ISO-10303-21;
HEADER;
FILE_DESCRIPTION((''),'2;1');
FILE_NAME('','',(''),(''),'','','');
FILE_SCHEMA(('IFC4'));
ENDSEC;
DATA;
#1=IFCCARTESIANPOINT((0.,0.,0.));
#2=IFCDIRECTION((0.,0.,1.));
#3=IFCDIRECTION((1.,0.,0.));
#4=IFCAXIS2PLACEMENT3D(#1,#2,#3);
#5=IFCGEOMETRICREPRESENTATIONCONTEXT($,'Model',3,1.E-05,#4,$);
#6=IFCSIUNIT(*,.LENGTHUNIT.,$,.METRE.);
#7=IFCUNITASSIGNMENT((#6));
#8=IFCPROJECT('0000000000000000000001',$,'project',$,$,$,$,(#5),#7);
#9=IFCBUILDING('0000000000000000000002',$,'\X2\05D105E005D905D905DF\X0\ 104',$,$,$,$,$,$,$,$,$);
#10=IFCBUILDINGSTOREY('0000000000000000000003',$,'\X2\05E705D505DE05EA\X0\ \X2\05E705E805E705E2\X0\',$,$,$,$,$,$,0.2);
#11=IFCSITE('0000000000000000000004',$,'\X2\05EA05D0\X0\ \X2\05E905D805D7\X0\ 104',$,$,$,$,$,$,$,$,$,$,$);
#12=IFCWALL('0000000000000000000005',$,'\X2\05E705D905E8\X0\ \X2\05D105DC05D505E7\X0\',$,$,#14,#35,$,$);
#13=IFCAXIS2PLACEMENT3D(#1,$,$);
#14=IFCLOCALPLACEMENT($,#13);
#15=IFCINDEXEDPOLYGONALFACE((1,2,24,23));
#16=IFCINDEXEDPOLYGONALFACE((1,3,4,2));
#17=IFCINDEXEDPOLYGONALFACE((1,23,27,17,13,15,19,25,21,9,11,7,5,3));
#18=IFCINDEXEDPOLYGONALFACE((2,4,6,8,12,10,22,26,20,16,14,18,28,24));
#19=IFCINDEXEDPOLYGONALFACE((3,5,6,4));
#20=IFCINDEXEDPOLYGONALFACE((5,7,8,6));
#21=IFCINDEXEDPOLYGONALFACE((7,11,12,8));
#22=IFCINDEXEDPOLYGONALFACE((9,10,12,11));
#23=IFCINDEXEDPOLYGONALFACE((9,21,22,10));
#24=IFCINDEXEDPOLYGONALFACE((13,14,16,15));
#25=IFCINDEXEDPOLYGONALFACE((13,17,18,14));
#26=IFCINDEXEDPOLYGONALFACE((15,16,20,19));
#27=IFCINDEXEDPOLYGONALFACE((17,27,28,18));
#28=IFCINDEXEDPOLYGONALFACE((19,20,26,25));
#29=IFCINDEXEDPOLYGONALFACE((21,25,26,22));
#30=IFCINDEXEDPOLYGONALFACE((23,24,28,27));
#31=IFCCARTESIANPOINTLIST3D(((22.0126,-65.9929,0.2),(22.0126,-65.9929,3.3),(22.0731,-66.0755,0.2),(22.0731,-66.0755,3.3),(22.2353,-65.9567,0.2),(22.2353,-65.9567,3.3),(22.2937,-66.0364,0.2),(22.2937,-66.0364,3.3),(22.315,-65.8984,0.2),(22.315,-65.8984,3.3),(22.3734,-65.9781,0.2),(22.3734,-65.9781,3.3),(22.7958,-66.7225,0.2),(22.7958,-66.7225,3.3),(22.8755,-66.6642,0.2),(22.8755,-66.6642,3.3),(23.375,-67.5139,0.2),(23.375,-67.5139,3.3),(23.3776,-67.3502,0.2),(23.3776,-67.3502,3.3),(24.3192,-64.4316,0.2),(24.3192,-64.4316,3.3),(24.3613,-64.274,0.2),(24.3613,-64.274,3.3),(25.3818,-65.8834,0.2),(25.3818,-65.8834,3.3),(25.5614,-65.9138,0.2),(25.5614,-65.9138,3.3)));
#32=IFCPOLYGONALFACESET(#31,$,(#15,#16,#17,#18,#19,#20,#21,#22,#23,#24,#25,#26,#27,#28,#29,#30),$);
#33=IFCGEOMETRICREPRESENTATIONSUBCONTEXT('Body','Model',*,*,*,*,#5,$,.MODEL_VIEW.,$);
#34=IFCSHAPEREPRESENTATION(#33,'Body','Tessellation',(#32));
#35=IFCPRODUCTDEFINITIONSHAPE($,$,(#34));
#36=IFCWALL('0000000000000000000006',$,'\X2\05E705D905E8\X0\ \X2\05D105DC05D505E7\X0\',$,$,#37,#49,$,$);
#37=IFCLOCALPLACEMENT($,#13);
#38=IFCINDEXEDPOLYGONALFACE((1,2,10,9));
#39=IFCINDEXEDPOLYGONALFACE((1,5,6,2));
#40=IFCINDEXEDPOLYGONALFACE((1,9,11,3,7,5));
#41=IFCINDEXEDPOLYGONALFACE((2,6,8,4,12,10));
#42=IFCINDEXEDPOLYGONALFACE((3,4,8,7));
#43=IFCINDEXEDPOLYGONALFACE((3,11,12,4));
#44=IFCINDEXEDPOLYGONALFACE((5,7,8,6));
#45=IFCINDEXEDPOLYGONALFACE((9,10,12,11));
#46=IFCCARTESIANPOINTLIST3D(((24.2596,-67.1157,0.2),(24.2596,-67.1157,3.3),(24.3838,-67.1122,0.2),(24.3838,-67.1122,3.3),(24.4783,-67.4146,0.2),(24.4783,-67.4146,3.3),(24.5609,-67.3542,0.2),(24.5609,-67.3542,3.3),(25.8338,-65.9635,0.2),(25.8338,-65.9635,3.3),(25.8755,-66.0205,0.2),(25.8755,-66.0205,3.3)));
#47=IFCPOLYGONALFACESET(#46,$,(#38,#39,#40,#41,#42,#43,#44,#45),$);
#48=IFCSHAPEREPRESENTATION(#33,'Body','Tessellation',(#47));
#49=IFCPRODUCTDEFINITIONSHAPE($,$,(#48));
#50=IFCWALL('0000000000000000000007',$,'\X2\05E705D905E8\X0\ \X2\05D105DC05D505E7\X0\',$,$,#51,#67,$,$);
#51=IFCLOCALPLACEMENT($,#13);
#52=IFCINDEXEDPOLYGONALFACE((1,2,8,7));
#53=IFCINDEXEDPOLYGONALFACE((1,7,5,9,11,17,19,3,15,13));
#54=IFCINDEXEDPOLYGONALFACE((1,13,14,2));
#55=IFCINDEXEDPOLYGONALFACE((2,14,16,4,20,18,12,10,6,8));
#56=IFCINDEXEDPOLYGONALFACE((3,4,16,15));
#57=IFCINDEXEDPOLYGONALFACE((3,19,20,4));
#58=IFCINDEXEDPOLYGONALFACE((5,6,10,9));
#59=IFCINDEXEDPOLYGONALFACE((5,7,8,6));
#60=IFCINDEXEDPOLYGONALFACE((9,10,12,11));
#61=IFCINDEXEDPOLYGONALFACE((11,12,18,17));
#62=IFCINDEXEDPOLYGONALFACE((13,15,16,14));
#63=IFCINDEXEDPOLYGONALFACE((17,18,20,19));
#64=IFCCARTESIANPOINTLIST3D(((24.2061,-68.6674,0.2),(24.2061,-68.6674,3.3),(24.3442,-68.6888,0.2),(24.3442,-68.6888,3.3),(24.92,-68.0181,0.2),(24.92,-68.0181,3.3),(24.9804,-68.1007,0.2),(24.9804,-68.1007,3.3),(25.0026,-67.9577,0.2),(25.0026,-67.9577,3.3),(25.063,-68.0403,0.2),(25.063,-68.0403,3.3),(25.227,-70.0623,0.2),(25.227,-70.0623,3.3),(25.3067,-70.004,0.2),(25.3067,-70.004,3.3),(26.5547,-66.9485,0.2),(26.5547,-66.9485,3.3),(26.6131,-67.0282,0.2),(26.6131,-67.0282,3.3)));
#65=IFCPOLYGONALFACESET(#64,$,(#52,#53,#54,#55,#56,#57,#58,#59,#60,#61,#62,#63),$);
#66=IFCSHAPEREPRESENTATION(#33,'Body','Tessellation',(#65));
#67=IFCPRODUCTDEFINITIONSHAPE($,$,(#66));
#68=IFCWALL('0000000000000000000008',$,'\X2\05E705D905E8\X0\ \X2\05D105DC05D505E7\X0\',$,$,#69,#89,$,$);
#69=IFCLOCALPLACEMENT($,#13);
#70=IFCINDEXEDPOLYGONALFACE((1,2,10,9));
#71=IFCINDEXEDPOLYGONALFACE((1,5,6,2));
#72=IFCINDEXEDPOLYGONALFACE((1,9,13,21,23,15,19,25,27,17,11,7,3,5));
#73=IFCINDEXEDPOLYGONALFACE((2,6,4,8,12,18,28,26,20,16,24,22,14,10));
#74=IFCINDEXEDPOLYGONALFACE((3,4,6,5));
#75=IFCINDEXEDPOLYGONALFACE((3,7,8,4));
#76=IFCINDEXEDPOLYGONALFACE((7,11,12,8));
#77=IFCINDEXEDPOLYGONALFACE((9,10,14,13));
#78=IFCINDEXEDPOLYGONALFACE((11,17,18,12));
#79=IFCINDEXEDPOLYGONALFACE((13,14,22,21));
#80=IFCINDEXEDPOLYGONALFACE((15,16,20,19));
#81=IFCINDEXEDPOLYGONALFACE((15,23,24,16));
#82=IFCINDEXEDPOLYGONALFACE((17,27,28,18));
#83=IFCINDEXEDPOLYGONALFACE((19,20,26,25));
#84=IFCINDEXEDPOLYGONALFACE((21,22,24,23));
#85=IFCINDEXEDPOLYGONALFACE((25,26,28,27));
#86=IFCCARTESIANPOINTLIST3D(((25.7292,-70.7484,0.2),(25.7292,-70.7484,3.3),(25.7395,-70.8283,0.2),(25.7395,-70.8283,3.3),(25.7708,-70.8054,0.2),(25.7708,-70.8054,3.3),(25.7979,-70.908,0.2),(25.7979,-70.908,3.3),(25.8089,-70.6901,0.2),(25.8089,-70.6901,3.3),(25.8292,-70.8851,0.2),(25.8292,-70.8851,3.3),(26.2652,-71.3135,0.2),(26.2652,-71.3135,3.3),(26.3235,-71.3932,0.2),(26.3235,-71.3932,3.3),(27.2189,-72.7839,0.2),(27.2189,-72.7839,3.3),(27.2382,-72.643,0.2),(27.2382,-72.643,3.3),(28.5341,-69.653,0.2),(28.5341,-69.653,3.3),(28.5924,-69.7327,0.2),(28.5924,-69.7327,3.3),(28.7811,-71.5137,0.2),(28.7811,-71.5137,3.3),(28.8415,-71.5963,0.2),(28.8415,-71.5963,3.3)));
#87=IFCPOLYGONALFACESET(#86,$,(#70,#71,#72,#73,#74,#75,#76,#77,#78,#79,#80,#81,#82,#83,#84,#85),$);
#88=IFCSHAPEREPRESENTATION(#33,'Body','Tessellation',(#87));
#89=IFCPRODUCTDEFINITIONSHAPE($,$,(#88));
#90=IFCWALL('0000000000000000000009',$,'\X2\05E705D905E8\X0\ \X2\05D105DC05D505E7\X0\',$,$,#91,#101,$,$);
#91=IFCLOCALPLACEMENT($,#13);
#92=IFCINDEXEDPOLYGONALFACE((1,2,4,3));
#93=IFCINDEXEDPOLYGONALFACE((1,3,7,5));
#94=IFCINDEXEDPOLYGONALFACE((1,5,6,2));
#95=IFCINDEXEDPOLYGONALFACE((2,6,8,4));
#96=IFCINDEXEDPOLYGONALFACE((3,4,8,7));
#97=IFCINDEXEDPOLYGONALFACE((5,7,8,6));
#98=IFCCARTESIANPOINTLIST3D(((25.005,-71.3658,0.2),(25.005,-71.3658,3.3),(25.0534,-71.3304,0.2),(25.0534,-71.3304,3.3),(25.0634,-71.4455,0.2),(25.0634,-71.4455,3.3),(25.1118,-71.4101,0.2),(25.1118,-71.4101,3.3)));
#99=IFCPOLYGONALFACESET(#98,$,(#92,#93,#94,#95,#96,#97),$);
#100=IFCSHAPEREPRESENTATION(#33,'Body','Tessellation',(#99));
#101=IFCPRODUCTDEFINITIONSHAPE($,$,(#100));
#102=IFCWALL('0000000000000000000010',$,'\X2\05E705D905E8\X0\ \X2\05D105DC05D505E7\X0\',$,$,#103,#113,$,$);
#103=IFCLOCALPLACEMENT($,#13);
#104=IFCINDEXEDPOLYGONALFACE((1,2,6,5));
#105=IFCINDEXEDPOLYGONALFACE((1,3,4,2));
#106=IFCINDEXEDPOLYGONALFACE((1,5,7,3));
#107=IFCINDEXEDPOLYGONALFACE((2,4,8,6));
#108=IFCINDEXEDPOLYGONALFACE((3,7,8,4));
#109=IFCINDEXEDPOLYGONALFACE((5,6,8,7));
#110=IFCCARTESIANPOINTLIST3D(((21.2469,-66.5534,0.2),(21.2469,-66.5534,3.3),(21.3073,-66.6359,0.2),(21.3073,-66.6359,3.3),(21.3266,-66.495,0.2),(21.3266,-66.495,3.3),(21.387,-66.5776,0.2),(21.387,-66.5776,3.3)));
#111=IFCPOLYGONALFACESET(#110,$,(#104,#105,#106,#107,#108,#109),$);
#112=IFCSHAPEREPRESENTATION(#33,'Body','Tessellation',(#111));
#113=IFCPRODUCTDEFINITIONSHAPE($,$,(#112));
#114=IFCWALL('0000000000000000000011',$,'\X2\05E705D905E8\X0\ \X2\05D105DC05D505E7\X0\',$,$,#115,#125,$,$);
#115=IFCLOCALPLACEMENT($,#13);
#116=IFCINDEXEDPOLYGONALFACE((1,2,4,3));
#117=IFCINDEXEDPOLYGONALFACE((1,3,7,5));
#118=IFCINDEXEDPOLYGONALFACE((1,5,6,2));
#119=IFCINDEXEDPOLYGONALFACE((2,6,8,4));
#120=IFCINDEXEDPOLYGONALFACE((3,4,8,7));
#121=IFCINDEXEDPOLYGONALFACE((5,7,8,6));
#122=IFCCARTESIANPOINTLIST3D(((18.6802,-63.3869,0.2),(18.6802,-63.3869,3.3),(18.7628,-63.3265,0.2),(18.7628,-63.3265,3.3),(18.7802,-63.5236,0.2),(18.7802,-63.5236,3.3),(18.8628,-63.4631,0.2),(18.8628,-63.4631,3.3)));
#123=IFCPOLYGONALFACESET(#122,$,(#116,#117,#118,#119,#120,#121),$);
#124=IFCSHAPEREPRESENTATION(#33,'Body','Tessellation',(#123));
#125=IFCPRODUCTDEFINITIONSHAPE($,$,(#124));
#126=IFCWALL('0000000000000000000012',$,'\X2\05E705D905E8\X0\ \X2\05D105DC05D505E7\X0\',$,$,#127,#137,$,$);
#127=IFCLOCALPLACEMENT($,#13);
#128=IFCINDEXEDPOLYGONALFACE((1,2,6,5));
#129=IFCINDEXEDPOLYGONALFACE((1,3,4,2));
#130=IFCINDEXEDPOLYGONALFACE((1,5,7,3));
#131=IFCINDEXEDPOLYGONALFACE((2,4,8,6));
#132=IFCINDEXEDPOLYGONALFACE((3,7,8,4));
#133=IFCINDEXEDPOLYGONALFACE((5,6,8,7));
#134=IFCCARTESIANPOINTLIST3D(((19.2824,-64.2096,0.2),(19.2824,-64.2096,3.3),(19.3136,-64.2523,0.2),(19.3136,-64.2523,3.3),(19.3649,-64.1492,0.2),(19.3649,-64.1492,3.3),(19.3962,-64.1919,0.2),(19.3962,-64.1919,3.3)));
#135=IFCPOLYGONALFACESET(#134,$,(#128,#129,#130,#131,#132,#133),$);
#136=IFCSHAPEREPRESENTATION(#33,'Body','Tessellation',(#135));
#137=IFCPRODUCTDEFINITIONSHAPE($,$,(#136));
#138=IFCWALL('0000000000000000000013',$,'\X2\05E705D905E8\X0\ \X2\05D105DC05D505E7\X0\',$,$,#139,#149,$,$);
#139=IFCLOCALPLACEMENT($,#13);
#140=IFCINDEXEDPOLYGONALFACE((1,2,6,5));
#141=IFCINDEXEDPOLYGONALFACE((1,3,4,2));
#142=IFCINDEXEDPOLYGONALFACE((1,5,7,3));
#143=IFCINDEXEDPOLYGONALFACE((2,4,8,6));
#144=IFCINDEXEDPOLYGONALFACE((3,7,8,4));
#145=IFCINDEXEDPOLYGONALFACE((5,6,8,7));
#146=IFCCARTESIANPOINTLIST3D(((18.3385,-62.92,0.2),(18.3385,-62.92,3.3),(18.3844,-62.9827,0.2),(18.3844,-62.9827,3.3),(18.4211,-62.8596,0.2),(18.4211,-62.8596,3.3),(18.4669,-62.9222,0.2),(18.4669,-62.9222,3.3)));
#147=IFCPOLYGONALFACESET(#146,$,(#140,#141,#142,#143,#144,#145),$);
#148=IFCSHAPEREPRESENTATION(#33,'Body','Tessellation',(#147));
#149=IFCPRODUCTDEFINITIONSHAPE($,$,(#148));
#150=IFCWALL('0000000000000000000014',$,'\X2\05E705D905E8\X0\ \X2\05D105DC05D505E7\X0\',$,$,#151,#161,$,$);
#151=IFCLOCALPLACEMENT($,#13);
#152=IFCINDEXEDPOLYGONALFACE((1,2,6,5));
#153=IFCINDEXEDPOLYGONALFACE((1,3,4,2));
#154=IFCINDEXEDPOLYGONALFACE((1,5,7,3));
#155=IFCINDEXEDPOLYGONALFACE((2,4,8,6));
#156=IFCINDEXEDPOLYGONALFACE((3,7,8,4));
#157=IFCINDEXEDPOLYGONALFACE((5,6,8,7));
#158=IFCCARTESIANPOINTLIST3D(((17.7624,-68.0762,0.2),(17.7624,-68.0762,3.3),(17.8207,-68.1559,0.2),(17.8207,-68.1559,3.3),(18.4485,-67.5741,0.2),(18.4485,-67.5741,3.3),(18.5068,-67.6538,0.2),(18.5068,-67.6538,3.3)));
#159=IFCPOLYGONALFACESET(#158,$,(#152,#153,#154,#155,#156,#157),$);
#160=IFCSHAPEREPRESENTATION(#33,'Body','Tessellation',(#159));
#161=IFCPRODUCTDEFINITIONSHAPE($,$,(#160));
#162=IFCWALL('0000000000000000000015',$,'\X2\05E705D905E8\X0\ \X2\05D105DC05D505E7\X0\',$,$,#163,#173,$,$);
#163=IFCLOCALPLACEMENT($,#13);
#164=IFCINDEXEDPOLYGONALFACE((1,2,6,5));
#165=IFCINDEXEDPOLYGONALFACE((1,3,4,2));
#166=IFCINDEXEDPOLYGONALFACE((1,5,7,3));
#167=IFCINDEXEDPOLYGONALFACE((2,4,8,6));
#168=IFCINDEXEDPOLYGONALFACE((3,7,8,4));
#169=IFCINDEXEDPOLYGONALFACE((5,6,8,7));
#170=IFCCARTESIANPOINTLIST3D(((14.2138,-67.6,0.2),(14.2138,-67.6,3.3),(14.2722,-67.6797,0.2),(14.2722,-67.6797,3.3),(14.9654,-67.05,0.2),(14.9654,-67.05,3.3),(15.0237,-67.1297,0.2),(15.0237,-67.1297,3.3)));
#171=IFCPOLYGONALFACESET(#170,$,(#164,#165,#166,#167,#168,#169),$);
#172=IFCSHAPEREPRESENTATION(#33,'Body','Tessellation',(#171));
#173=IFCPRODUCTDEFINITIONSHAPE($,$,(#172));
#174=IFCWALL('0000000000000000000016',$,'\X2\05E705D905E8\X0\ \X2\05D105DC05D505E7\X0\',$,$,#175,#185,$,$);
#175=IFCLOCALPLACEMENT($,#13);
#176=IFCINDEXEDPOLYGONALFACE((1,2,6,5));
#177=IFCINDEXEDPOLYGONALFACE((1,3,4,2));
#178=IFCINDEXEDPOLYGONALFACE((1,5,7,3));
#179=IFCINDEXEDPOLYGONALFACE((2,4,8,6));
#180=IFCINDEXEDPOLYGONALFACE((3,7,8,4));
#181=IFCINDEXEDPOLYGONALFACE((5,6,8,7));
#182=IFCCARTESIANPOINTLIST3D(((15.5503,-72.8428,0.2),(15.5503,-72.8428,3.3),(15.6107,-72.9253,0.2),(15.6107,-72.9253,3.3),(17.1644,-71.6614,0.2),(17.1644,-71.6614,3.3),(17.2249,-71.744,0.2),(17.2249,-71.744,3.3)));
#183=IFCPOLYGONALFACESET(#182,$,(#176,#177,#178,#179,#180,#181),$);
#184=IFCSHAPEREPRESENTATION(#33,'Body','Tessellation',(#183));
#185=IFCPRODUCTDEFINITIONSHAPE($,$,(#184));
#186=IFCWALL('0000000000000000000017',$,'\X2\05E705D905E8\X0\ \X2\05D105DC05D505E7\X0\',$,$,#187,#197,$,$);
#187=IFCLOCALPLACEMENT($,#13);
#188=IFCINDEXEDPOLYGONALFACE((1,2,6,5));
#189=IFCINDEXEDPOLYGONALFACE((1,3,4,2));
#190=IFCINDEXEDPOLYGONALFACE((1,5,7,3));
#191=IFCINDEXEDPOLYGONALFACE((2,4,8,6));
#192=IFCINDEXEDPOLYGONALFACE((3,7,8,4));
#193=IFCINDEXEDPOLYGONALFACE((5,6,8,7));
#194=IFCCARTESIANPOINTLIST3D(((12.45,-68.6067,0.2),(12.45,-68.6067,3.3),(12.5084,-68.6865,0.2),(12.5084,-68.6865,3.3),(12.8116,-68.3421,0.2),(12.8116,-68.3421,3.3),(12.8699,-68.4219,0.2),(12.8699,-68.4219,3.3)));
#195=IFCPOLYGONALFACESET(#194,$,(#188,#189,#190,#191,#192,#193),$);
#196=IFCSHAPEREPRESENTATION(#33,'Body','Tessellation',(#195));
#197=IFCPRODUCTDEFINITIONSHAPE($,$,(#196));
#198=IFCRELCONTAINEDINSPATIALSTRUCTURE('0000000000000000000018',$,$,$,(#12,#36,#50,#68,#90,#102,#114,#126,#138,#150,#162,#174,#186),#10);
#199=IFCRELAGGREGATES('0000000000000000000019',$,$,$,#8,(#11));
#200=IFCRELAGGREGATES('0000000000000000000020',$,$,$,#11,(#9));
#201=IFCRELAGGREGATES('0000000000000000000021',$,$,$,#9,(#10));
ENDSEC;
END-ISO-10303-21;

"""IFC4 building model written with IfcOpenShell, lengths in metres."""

from ifc_helpers import new_model, si_unit, frame, origin_with_axes, context, subcontext, project, spatial, polyline, outline, extrude, element, save


model = new_model("IFC4")

# Units and contexts
model_context = context("Model", 3, precision=1e-05, world=origin_with_axes())
body_context = subcontext(model_context, "Body", "Model", "MODEL_VIEW")
ifc_project = project(units=[si_unit("LENGTHUNIT", "METRE")], contexts=[model_context])

# Site, building, storey
site = spatial("IfcSite", under=ifc_project, Name="תא שטח 104")
building = spatial("IfcBuilding", under=site, Name="בניין 104")
storey = spatial("IfcBuildingStorey", under=building, Name="קומת קרקע", Elevation=0.2)

# Walls
element("IfcWall", 1, inside=storey, Name="קיר בלוק", context=body_context, shape_type="SweptSolid", body=[
    extrude(outline(polyline([(23.3776, -67.3502), (22.8755, -66.6642), (22.7958, -66.7225), (23.375, -67.5139), (25.5614, -65.9138), (24.3613, -64.274), (22.0126, -65.9929), (22.0731, -66.0755), (22.2353, -65.9567), (22.2937, -66.0364), (22.3734, -65.9781), (22.315, -65.8984), (24.3192, -64.4316), (25.3818, -65.8834), (23.3776, -67.3502)])), frame((0.0, 0.0, 0.2)), (0.0, 0.0, 1.0), 3.1),
])
element("IfcWall", 2, inside=storey, Name="קיר בלוק", context=body_context, shape_type="SweptSolid", body=[
    extrude(outline(polyline([(25.8338, -65.9635), (24.2596, -67.1157), (24.4783, -67.4146), (24.5609, -67.3542), (24.3838, -67.1122), (25.8755, -66.0205), (25.8338, -65.9635)])), frame((0.0, 0.0, 0.2)), (0.0, 0.0, 1.0), 3.1),
])
element("IfcWall", 3, inside=storey, Name="קיר בלוק", context=body_context, shape_type="SweptSolid", body=[
    extrude(outline(polyline([(24.2061, -68.6674), (25.227, -70.0623), (25.3067, -70.004), (24.3442, -68.6888), (26.6131, -67.0282), (26.5547, -66.9485), (25.063, -68.0403), (25.0026, -67.9577), (24.92, -68.0181), (24.9804, -68.1007), (24.2061, -68.6674)])), frame((0.0, 0.0, 0.2)), (0.0, 0.0, 1.0), 3.1),
])
element("IfcWall", 4, inside=storey, Name="קיר בלוק", context=body_context, shape_type="SweptSolid", body=[
    extrude(outline(polyline([(26.2652, -71.3135), (25.8089, -70.6901), (25.7292, -70.7484), (25.7708, -70.8054), (25.7395, -70.8283), (25.7979, -70.908), (25.8292, -70.8851), (27.2189, -72.7839), (28.8415, -71.5963), (28.7811, -71.5137), (27.2382, -72.643), (26.3235, -71.3932), (28.5924, -69.7327), (28.5341, -69.653), (26.2652, -71.3135)])), frame((0.0, 0.0, 0.2)), (0.0, 0.0, 1.0), 3.1),
])
element("IfcWall", 5, inside=storey, Name="קיר בלוק", context=body_context, shape_type="SweptSolid", body=[
    extrude(outline(polyline([(25.0534, -71.3304), (25.005, -71.3658), (25.0634, -71.4455), (25.1118, -71.4101), (25.0534, -71.3304)])), frame((0.0, 0.0, 0.2)), (0.0, 0.0, 1.0), 3.1),
])
element("IfcWall", 6, inside=storey, Name="קיר בלוק", context=body_context, shape_type="SweptSolid", body=[
    extrude(outline(polyline([(21.387, -66.5776), (21.3266, -66.495), (21.2469, -66.5534), (21.3073, -66.6359), (21.387, -66.5776)])), frame((0.0, 0.0, 0.2)), (0.0, 0.0, 1.0), 3.1),
])
element("IfcWall", 7, inside=storey, Name="קיר בלוק", context=body_context, shape_type="SweptSolid", body=[
    extrude(outline(polyline([(18.7628, -63.3265), (18.6802, -63.3869), (18.7802, -63.5236), (18.8628, -63.4631), (18.7628, -63.3265)])), frame((0.0, 0.0, 0.2)), (0.0, 0.0, 1.0), 3.1),
])
element("IfcWall", 8, inside=storey, Name="קיר בלוק", context=body_context, shape_type="SweptSolid", body=[
    extrude(outline(polyline([(19.3962, -64.1919), (19.3649, -64.1492), (19.2824, -64.2096), (19.3136, -64.2523), (19.3962, -64.1919)])), frame((0.0, 0.0, 0.2)), (0.0, 0.0, 1.0), 3.1),
])
element("IfcWall", 9, inside=storey, Name="קיר בלוק", context=body_context, shape_type="SweptSolid", body=[
    extrude(outline(polyline([(18.4211, -62.8596), (18.3385, -62.92), (18.3844, -62.9827), (18.4669, -62.9222), (18.4211, -62.8596)])), frame((0.0, 0.0, 0.2)), (0.0, 0.0, 1.0), 3.1),
])
element("IfcWall", 10, inside=storey, Name="קיר בלוק", context=body_context, shape_type="SweptSolid", body=[
    extrude(outline(polyline([(18.4485, -67.5741), (17.7624, -68.0762), (17.8207, -68.1559), (18.5068, -67.6538), (18.4485, -67.5741)])), frame((0.0, 0.0, 0.2)), (0.0, 0.0, 1.0), 3.1),
])
element("IfcWall", 11, inside=storey, Name="קיר בלוק", context=body_context, shape_type="SweptSolid", body=[
    extrude(outline(polyline([(15.0237, -67.1297), (14.9654, -67.05), (14.2138, -67.6), (14.2722, -67.6797), (15.0237, -67.1297)])), frame((0.0, 0.0, 0.2)), (0.0, 0.0, 1.0), 3.1),
])
element("IfcWall", 12, inside=storey, Name="קיר בלוק", context=body_context, shape_type="SweptSolid", body=[
    extrude(outline(polyline([(17.2249, -71.744), (17.1644, -71.6614), (15.5503, -72.8428), (15.6107, -72.9253), (17.2249, -71.744)])), frame((0.0, 0.0, 0.2)), (0.0, 0.0, 1.0), 3.1),
])
element("IfcWall", 13, inside=storey, Name="קיר בלוק", context=body_context, shape_type="SweptSolid", body=[
    extrude(outline(polyline([(12.5084, -68.6865), (12.8699, -68.4219), (12.8116, -68.3421), (12.45, -68.6067), (12.5084, -68.6865)])), frame((0.0, 0.0, 0.2)), (0.0, 0.0, 1.0), 3.1),
])

save(model, "model.ifc")
